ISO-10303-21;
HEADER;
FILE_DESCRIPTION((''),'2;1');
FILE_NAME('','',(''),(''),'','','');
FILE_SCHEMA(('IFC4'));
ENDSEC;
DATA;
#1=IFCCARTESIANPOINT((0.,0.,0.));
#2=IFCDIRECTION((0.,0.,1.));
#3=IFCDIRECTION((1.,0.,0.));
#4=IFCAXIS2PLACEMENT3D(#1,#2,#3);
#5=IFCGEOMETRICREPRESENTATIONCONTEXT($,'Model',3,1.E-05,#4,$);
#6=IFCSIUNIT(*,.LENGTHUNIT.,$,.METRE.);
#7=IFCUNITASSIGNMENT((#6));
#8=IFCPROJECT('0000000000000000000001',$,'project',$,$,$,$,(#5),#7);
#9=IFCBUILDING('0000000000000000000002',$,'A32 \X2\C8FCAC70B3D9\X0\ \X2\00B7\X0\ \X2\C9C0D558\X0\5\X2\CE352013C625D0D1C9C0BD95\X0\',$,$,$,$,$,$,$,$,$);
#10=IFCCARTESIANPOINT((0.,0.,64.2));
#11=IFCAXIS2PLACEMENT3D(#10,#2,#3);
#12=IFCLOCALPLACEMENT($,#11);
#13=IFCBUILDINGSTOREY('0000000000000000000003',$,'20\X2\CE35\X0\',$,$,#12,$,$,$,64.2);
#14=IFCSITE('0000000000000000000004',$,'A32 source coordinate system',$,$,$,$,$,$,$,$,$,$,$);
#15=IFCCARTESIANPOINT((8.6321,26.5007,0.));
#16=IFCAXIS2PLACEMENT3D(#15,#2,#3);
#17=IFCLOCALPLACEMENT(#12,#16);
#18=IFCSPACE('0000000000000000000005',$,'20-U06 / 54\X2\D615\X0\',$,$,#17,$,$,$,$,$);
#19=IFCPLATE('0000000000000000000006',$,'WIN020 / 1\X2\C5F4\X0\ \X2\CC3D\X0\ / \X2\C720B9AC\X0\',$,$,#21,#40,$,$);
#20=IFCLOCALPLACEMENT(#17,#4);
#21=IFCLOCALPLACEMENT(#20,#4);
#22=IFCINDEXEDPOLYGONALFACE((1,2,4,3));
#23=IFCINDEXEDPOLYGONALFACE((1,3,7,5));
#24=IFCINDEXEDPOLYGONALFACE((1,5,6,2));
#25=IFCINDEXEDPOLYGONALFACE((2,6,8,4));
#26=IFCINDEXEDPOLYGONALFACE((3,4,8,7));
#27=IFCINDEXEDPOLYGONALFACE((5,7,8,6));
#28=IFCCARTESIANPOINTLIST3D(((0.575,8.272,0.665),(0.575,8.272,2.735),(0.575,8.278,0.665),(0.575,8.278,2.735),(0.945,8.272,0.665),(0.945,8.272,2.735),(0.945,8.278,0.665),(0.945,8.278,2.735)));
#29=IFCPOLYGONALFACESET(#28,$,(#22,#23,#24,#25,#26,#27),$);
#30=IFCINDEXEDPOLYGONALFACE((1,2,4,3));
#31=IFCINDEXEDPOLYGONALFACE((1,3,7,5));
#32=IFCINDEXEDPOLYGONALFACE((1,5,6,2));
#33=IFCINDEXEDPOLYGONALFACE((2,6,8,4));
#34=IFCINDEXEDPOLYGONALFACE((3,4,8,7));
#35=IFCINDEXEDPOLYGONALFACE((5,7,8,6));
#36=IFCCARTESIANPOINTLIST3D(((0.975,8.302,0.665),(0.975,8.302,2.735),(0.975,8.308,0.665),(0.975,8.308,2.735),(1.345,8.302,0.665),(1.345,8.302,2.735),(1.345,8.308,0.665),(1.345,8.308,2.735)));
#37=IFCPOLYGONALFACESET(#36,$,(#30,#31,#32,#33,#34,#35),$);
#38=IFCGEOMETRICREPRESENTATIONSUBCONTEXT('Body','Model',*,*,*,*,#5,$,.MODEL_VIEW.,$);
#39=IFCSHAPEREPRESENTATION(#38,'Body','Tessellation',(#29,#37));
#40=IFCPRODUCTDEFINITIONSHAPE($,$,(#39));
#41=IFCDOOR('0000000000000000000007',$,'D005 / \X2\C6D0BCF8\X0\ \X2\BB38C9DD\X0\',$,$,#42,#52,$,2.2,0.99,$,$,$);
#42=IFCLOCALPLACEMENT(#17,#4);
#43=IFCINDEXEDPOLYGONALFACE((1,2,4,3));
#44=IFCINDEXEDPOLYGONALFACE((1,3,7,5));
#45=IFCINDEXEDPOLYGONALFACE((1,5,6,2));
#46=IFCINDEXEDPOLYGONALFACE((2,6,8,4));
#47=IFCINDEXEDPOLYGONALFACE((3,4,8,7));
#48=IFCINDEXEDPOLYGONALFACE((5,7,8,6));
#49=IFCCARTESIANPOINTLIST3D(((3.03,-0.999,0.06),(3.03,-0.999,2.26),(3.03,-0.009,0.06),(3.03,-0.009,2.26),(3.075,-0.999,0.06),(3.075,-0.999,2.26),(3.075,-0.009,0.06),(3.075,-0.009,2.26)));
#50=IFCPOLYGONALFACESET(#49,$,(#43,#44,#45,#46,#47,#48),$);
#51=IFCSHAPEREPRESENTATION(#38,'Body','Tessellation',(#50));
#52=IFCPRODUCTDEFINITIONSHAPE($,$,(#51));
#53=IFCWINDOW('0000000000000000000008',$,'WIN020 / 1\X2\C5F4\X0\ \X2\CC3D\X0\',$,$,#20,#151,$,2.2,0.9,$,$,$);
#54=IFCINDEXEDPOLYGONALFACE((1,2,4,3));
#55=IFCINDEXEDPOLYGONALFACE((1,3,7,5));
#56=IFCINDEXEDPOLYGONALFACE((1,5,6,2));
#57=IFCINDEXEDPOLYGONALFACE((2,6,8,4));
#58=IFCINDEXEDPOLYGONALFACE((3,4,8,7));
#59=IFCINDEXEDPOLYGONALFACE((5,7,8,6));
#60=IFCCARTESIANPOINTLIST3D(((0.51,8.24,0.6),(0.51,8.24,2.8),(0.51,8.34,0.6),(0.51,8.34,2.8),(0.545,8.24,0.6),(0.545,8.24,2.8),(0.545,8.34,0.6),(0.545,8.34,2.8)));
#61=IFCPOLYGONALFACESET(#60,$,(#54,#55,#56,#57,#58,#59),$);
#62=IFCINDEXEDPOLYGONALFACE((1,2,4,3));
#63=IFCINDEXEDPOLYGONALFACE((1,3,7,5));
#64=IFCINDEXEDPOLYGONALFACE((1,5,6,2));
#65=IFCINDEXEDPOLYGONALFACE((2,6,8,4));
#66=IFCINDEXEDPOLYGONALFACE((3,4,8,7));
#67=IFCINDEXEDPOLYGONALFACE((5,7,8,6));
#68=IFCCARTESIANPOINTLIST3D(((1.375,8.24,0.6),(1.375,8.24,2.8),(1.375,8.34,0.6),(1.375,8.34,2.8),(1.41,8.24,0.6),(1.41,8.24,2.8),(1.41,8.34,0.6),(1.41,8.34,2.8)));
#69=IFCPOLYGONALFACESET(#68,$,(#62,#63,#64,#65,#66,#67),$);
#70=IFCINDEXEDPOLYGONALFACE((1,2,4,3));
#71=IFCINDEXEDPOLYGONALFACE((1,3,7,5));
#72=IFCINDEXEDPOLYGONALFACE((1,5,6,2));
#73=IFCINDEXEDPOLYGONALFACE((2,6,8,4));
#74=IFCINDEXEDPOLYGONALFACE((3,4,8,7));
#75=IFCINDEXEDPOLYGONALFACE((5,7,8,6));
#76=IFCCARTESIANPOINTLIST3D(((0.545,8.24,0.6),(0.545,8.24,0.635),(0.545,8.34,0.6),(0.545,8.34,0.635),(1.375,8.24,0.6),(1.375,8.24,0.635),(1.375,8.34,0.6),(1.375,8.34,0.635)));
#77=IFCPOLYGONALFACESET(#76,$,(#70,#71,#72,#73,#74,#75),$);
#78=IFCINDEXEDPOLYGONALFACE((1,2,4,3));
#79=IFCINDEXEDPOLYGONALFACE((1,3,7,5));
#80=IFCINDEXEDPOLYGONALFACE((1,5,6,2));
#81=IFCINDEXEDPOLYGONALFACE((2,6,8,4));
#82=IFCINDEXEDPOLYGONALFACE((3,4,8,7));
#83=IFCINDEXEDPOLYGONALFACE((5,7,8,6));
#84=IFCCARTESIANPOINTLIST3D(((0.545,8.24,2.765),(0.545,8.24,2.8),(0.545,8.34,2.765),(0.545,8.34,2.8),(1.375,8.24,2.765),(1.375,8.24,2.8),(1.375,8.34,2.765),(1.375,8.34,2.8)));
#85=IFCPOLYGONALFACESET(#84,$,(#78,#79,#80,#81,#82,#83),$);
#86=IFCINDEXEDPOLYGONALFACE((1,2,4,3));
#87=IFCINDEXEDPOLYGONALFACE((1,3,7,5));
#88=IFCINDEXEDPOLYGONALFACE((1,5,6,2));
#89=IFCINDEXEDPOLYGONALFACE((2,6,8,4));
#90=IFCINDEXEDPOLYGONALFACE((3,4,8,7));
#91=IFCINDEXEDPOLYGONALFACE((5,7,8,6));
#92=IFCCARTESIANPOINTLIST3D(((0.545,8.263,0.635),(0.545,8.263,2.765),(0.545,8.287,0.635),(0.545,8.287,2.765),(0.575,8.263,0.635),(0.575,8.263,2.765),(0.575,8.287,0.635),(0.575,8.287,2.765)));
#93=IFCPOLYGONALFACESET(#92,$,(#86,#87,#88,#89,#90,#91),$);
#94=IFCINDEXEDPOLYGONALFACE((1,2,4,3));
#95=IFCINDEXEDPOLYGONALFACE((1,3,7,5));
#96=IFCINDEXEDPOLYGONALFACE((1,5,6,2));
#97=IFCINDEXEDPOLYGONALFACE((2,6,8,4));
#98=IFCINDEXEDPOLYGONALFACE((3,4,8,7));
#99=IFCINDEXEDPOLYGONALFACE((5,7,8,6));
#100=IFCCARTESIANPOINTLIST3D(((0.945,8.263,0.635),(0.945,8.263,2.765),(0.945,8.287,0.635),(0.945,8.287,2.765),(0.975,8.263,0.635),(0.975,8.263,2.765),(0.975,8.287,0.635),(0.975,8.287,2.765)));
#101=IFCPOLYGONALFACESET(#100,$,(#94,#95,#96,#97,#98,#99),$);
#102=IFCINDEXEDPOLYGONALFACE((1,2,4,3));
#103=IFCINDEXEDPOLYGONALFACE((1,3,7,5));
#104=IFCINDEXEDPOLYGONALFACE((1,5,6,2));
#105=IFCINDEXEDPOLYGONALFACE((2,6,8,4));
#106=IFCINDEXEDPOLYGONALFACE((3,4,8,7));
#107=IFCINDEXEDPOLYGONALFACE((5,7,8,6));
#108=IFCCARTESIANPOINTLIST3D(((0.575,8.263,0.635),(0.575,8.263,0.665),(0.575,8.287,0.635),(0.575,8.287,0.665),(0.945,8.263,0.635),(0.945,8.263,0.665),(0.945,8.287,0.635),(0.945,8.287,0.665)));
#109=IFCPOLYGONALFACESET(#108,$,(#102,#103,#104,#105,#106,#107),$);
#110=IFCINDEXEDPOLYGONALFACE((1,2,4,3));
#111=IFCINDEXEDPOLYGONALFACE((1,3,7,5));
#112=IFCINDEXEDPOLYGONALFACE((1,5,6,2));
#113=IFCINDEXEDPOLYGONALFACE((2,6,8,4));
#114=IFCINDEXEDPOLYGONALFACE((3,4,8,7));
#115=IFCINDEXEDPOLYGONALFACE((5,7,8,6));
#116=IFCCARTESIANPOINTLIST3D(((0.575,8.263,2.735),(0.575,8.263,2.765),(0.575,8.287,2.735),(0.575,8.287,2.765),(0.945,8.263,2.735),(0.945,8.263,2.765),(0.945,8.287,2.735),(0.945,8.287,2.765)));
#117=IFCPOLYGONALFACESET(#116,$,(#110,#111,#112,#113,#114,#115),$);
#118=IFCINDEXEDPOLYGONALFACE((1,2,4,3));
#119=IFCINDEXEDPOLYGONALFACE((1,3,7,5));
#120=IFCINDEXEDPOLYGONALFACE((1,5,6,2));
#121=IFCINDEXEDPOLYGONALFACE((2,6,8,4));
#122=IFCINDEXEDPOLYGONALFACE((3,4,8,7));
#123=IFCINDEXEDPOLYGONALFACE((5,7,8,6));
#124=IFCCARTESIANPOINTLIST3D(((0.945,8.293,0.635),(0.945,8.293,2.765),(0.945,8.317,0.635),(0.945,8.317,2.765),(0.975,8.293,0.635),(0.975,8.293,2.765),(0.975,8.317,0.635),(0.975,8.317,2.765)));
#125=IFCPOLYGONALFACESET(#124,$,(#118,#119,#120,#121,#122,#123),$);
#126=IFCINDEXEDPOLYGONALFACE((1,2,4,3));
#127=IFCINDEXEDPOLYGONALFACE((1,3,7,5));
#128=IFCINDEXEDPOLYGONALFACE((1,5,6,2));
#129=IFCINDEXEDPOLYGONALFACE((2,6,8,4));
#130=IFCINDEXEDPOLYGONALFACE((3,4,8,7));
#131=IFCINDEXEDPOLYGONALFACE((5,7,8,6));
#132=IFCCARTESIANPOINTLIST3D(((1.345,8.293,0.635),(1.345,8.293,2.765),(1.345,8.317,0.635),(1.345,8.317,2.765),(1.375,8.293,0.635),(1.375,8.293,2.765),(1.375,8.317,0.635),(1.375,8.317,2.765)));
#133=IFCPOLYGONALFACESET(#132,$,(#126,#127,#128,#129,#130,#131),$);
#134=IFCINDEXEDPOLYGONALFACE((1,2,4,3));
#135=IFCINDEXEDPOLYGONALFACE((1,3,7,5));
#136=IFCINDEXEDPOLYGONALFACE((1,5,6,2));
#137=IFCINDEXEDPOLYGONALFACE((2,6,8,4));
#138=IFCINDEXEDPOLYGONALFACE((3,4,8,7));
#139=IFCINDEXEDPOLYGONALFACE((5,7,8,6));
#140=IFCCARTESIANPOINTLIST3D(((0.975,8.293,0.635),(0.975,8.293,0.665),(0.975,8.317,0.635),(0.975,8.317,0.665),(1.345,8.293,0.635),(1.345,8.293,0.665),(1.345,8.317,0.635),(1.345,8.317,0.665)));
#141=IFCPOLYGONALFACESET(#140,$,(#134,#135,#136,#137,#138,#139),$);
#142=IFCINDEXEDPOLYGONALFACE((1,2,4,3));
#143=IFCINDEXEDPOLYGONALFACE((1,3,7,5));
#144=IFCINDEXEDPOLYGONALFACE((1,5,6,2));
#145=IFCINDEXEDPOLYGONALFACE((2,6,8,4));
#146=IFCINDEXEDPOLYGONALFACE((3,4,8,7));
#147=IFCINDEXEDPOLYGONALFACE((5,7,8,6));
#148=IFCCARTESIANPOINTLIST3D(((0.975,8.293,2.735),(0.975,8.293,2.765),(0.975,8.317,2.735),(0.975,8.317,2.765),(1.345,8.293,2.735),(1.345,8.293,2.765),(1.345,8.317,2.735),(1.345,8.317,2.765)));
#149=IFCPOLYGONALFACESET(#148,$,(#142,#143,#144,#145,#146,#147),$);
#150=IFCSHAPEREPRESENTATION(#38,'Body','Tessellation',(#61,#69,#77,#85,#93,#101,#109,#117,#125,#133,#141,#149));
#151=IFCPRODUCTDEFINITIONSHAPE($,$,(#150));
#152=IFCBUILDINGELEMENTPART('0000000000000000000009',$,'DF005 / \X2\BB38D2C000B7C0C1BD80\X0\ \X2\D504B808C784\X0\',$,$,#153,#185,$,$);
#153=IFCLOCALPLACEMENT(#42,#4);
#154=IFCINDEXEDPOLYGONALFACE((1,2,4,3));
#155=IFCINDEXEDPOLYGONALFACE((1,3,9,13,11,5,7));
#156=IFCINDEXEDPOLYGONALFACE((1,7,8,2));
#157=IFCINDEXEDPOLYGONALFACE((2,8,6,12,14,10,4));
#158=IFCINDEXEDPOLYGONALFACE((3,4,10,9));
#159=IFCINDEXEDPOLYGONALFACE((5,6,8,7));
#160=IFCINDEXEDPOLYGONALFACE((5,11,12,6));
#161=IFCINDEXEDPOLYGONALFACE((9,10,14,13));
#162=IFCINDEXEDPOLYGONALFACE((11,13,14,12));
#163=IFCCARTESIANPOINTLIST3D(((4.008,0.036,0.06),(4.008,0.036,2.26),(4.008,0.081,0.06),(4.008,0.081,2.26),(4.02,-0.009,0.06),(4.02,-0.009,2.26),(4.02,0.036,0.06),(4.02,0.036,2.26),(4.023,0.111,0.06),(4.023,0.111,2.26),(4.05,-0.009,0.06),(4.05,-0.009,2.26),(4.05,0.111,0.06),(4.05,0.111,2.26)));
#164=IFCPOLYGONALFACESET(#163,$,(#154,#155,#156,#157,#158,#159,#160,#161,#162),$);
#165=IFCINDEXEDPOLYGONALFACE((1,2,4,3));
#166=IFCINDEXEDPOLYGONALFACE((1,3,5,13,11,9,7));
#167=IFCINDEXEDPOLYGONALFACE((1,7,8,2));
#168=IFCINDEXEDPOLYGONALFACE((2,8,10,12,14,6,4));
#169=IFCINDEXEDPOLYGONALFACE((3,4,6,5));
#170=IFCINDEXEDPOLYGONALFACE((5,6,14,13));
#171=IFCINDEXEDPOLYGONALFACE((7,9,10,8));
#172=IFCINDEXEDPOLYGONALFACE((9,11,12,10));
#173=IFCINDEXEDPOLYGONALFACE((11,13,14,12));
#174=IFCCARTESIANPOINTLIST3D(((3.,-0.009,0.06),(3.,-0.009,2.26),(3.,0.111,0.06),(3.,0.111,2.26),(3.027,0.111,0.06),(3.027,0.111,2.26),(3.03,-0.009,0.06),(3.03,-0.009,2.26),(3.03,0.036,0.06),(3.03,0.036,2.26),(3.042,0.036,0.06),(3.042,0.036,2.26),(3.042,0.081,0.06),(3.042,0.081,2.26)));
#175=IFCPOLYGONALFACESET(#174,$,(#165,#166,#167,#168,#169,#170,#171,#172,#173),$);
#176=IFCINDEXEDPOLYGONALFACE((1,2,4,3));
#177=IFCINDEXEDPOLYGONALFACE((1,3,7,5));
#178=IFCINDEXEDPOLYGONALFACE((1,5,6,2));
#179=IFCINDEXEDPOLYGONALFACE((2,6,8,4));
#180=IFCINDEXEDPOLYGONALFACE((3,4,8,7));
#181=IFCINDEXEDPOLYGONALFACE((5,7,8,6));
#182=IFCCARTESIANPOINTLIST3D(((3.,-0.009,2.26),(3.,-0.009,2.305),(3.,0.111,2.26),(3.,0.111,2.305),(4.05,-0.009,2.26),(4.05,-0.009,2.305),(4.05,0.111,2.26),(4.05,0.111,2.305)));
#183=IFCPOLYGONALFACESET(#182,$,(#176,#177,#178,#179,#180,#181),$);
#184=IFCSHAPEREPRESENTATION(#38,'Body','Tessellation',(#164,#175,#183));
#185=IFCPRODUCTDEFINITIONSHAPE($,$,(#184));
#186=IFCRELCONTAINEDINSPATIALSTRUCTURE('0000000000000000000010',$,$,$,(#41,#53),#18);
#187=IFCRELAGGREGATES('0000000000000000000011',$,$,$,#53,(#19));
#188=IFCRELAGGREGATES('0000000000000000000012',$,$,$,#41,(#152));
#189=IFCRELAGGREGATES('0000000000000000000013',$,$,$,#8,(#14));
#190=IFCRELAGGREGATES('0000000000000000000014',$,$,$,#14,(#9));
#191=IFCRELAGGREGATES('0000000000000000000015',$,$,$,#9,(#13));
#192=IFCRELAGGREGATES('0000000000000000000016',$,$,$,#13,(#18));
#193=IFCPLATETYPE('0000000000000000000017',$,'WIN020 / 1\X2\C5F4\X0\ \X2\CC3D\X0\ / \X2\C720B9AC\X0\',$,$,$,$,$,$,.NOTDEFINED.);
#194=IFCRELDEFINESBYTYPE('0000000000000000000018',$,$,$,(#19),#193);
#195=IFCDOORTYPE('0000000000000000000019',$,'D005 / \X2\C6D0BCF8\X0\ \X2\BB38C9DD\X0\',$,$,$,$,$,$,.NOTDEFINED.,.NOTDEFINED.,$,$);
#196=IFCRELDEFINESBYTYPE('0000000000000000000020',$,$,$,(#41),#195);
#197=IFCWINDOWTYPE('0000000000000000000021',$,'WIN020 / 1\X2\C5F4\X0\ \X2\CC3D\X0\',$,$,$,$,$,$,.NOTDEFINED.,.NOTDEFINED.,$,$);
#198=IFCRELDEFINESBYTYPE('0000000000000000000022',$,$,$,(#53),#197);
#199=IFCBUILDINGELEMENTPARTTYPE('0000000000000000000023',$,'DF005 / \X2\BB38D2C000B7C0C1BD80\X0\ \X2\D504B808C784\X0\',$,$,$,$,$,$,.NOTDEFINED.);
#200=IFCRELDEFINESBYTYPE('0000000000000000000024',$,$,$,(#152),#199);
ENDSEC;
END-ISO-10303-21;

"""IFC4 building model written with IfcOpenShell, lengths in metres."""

from ifc_helpers import new_model, si_unit, frame, origin, origin_with_axes, place, context, subcontext, project, spatial, polyline, outline, extrude, source, transform, mapped, type_object, type_shapes, element, aggregate, save


model = new_model("IFC4")

# Units and contexts
model_context = context("Model", 3, precision=1e-05, world=origin_with_axes())
body_context = subcontext(model_context, "Body", "Model", "MODEL_VIEW")
ifc_project = project(units=[si_unit("LENGTHUNIT", "METRE")], contexts=[model_context])

# Plate
storey_placement = place(None, frame((0.0, 0.0, 64.2), z_axis=(0.0, 0.0, 1.0), x_axis=(1.0, 0.0, 0.0)))
space_1_placement = place(storey_placement, frame((8.6321, 26.5007, 0.0), z_axis=(0.0, 0.0, 1.0), x_axis=(1.0, 0.0, 0.0)))
plate_type_1 = type_object("IfcPlateType", Name="WIN020 / 1열 창 / 유리", PredefinedType="NOTDEFINED")
shared_shape_1 = source(origin(), body_context, "Body", "SweptSolid", [
    extrude(outline(polyline([(0.575, 8.272), (0.575, 8.278), (0.945, 8.278), (0.945, 8.272), (0.575, 8.272)])), frame((0.0, 0.0, 0.665)), (0.0, 0.0, 1.0), 2.07),
    extrude(outline(polyline([(0.975, 8.302), (0.975, 8.308), (1.345, 8.308), (1.345, 8.302), (0.975, 8.302)])), frame((0.0, 0.0, 0.665)), (0.0, 0.0, 1.0), 2.07),
])
type_shapes(plate_type_1, [shared_shape_1])
window_1_placement = place(space_1_placement, origin_with_axes())
plate_1_placement = place(window_1_placement, origin_with_axes())
plate_1 = element("IfcPlate", 1, at=plate_1_placement, type_object=plate_type_1, Name="WIN020 / 1열 창 / 유리", context=body_context, shape_type="MappedRepresentation", body=[
    mapped(shared_shape_1, transform((0.0, 0.0, 0.0), scale=1.0)),
])

# Site, building, storey, space
site = spatial("IfcSite", under=ifc_project, Name="A32 source coordinate system")
building = spatial("IfcBuilding", under=site, Name="A32 주거동 · 지하5층–옥탑지붕")
storey = spatial("IfcBuildingStorey", under=building, at=storey_placement, Name="20층", Elevation=64.2)
space_1 = spatial("IfcSpace", under=storey, at=space_1_placement, Name="20-U06 / 54형")

# Door
door_type_1 = type_object("IfcDoorType", Name="D005 / 원본 문짝", OperationType="NOTDEFINED", PredefinedType="NOTDEFINED")
shared_shape_2 = source(origin(), body_context, "Body", "SweptSolid", [
    extrude(outline(polyline([(3.075, -0.999), (3.03, -0.999), (3.03, -0.009), (3.075, -0.009), (3.075, -0.999)])), frame((0.0, 0.0, 0.06)), (0.0, 0.0, 1.0), 2.2),
])
type_shapes(door_type_1, [shared_shape_2])
door_1_placement = place(space_1_placement, origin_with_axes())
door_1 = element("IfcDoor", 2, at=door_1_placement, inside=space_1, type_object=door_type_1, Name="D005 / 원본 문짝", OverallHeight=2.2, OverallWidth=0.99, context=body_context, shape_type="MappedRepresentation", body=[
    mapped(shared_shape_2, transform((0.0, 0.0, 0.0), scale=1.0)),
])

# Window
window_type_1 = type_object("IfcWindowType", Name="WIN020 / 1열 창", PartitioningType="NOTDEFINED", PredefinedType="NOTDEFINED")
shared_shape_3 = source(origin(), body_context, "Body", "SweptSolid", [
    extrude(outline(polyline([(0.51, 8.24), (0.51, 8.34), (0.545, 8.34), (0.545, 8.24), (0.51, 8.24)])), frame((0.0, 0.0, 0.6)), (0.0, 0.0, 1.0), 2.2),
    extrude(outline(polyline([(1.375, 8.24), (1.375, 8.34), (1.41, 8.34), (1.41, 8.24), (1.375, 8.24)])), frame((0.0, 0.0, 0.6)), (0.0, 0.0, 1.0), 2.2),
    extrude(outline(polyline([(0.545, 8.24), (0.545, 8.34), (1.375, 8.34), (1.375, 8.24), (0.545, 8.24)])), frame((0.0, 0.0, 0.6)), (0.0, 0.0, 1.0), 0.035),
    extrude(outline(polyline([(0.545, 8.24), (0.545, 8.34), (1.375, 8.34), (1.375, 8.24), (0.545, 8.24)])), frame((0.0, 0.0, 2.765)), (0.0, 0.0, 1.0), 0.035),
    extrude(outline(polyline([(0.545, 8.263), (0.545, 8.287), (0.575, 8.287), (0.575, 8.263), (0.545, 8.263)])), frame((0.0, 0.0, 0.635)), (0.0, 0.0, 1.0), 2.13),
    extrude(outline(polyline([(0.945, 8.263), (0.945, 8.287), (0.975, 8.287), (0.975, 8.263), (0.945, 8.263)])), frame((0.0, 0.0, 0.635)), (0.0, 0.0, 1.0), 2.13),
    extrude(outline(polyline([(0.575, 8.263), (0.575, 8.287), (0.945, 8.287), (0.945, 8.263), (0.575, 8.263)])), frame((0.0, 0.0, 0.635)), (0.0, 0.0, 1.0), 0.03),
    extrude(outline(polyline([(0.575, 8.263), (0.575, 8.287), (0.945, 8.287), (0.945, 8.263), (0.575, 8.263)])), frame((0.0, 0.0, 2.735)), (0.0, 0.0, 1.0), 0.03),
    extrude(outline(polyline([(0.945, 8.293), (0.945, 8.317), (0.975, 8.317), (0.975, 8.293), (0.945, 8.293)])), frame((0.0, 0.0, 0.635)), (0.0, 0.0, 1.0), 2.13),
    extrude(outline(polyline([(1.345, 8.293), (1.345, 8.317), (1.375, 8.317), (1.375, 8.293), (1.345, 8.293)])), frame((0.0, 0.0, 0.635)), (0.0, 0.0, 1.0), 2.13),
    extrude(outline(polyline([(0.975, 8.293), (0.975, 8.317), (1.345, 8.317), (1.345, 8.293), (0.975, 8.293)])), frame((0.0, 0.0, 0.635)), (0.0, 0.0, 1.0), 0.03),
    extrude(outline(polyline([(0.975, 8.293), (0.975, 8.317), (1.345, 8.317), (1.345, 8.293), (0.975, 8.293)])), frame((0.0, 0.0, 2.735)), (0.0, 0.0, 1.0), 0.03),
])
type_shapes(window_type_1, [shared_shape_3])
window_1 = element("IfcWindow", 3, at=window_1_placement, inside=space_1, type_object=window_type_1, Name="WIN020 / 1열 창", OverallHeight=2.2, OverallWidth=0.9, context=body_context, shape_type="MappedRepresentation", body=[
    mapped(shared_shape_3, transform((0.0, 0.0, 0.0), scale=1.0)),
])
aggregate(window_1, [plate_1])

# Building element part
building_element_part_type_1 = type_object("IfcBuildingElementPartType", Name="DF005 / 문틀·상부 프레임", PredefinedType="NOTDEFINED")
shared_shape_4 = source(origin(), body_context, "Body", "SweptSolid", [
    extrude(outline(polyline([(4.02, -0.009), (4.02, 0.036), (4.008, 0.036), (4.008, 0.081), (4.023, 0.111), (4.05, 0.111), (4.05, -0.009), (4.02, -0.009)])), frame((0.0, 0.0, 0.06)), (0.0, 0.0, 1.0), 2.2),
    extrude(outline(polyline([(3.0, 0.111), (3.027, 0.111), (3.042, 0.081), (3.042, 0.036), (3.03, 0.036), (3.03, -0.009), (3.0, -0.009), (3.0, 0.111)])), frame((0.0, 0.0, 0.06)), (0.0, 0.0, 1.0), 2.2),
    extrude(outline(polyline([(3.0, -0.009), (3.0, 0.111), (4.05, 0.111), (4.05, -0.009), (3.0, -0.009)])), frame((0.0, 0.0, 2.26)), (0.0, 0.0, 1.0), 0.045),
])
type_shapes(building_element_part_type_1, [shared_shape_4])
building_element_part_1_placement = place(door_1_placement, origin_with_axes())
building_element_part_1 = element("IfcBuildingElementPart", 4, at=building_element_part_1_placement, type_object=building_element_part_type_1, Name="DF005 / 문틀·상부 프레임", context=body_context, shape_type="MappedRepresentation", body=[
    mapped(shared_shape_4, transform((0.0, 0.0, 0.0), scale=1.0)),
])
aggregate(door_1, [building_element_part_1])

save(model, "model.ifc")
